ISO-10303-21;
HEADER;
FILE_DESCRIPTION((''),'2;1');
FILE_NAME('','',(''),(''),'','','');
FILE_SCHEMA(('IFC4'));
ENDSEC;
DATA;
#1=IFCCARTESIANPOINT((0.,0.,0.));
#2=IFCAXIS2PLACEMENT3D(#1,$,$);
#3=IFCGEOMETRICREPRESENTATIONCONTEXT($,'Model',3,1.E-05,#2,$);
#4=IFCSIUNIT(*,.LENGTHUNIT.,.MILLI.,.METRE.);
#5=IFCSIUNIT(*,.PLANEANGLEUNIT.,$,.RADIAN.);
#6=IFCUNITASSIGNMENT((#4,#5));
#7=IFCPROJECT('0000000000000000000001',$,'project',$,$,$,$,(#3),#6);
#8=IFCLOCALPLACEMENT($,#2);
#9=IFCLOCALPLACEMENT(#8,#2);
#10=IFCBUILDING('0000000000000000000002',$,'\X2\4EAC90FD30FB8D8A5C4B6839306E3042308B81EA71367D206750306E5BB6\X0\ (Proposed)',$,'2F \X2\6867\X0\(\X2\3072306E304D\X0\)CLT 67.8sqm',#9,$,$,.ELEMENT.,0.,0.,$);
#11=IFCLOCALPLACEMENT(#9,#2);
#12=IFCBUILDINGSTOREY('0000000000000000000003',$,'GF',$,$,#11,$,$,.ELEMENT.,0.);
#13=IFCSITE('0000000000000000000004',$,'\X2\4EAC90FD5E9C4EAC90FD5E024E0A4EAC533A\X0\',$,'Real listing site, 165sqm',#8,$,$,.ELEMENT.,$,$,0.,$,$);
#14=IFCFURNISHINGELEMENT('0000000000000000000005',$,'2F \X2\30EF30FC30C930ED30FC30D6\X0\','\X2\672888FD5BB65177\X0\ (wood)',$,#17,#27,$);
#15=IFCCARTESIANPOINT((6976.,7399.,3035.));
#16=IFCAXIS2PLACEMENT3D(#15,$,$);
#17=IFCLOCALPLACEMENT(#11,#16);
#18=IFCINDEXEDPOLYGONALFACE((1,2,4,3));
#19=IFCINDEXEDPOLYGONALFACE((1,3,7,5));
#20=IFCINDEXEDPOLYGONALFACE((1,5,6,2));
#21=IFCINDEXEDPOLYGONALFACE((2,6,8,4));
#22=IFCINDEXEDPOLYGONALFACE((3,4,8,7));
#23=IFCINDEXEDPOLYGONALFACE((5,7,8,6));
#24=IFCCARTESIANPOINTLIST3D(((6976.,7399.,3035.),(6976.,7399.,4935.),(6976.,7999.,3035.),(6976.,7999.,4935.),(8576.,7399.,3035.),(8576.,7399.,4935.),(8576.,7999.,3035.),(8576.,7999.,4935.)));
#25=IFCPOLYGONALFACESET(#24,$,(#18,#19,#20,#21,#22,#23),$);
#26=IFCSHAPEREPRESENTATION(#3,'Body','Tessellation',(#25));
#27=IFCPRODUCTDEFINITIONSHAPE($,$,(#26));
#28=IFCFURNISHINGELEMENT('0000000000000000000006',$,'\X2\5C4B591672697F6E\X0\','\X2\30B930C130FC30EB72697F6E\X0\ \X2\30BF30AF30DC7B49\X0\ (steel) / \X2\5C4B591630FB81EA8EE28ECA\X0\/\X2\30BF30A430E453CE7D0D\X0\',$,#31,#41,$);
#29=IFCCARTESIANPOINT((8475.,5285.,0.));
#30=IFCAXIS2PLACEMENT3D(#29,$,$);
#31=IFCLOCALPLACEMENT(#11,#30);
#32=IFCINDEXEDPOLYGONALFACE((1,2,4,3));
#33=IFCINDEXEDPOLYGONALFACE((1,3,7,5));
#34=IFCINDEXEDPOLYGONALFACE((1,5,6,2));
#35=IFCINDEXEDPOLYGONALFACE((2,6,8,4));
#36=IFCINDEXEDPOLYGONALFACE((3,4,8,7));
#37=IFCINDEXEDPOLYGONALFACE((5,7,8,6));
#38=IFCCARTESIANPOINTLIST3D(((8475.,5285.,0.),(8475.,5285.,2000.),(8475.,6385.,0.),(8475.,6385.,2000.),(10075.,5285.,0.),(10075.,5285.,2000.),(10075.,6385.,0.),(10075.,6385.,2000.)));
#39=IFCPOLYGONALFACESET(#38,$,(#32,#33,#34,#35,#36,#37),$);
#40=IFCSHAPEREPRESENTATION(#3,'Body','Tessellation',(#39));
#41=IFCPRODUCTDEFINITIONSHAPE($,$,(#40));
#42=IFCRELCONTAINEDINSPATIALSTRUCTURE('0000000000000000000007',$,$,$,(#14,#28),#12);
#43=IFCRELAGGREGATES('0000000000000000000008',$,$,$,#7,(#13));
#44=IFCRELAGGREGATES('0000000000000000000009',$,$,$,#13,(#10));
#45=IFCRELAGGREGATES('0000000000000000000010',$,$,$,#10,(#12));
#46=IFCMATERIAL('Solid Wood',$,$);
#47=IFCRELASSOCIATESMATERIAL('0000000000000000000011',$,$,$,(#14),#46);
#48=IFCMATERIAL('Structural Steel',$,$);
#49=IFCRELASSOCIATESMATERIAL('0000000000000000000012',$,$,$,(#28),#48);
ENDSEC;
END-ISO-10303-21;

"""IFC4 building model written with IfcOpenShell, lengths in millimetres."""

from ifc_helpers import new_model, si_unit, frame, frame_2d, origin, place, context, project, spatial, rectangle, extrude, material, element, save


model = new_model("IFC4")

# Units and contexts
model_context = context("Model", 3, precision=1e-05, world=origin())
ifc_project = project(units=[si_unit("LENGTHUNIT", "METRE", prefix="MILLI"), si_unit("PLANEANGLEUNIT", "RADIAN")], contexts=[model_context])

# Site, building, storey
site_placement = place(None, origin())
site = spatial("IfcSite", under=ifc_project, at=site_placement, Name="京都府京都市上京区", ObjectType="Real listing site, 165sqm", CompositionType="ELEMENT", RefElevation=0.0)
building_placement = place(site_placement, origin())
building = spatial("IfcBuilding", under=site, at=building_placement, Name="京都・越屋根のある自然素材の家 (Proposed)", ObjectType="2F 桧(ひのき)CLT 67.8sqm", CompositionType="ELEMENT", ElevationOfRefHeight=0.0, ElevationOfTerrain=0.0)
storey_placement = place(building_placement, origin())
storey = spatial("IfcBuildingStorey", under=building, at=storey_placement, Name="GF", CompositionType="ELEMENT", Elevation=0.0)

# Shared definitions
ifc_material_1 = material(Name="Solid Wood")

# Shared definitions
ifc_material_2 = material(Name="Structural Steel")

# Furnishing elements
furnishing_1_placement = place(storey_placement, frame((6976.0, 7399.0, 3035.0)))
element("IfcFurnishingElement", 1, at=furnishing_1_placement, inside=storey, material=ifc_material_1, Name="2F ワードローブ", Description="木製家具 (wood)", context=model_context, shape_type="SweptSolid", body=[
    extrude(rectangle(XDim=1600.0, YDim=600.0, at=frame_2d((800.0, 300.0))), frame((6976.0, 7399.0, 3035.0)), (0.0, 0.0, 1.0), 1900.0),
])
furnishing_2_placement = place(storey_placement, frame((8475.0, 5285.0, 0.0)))
element("IfcFurnishingElement", 2, at=furnishing_2_placement, inside=storey, material=ifc_material_2, Name="屋外物置", Description="スチール物置 タクボ等 (steel) / 屋外・自転車/タイヤ収納", context=model_context, shape_type="SweptSolid", body=[
    extrude(rectangle(XDim=1600.0, YDim=1100.0, at=frame_2d((800.0, 550.0))), frame((8475.0, 5285.0, 0.0)), (0.0, 0.0, 1.0), 2000.0),
])

save(model, "model.ifc")
